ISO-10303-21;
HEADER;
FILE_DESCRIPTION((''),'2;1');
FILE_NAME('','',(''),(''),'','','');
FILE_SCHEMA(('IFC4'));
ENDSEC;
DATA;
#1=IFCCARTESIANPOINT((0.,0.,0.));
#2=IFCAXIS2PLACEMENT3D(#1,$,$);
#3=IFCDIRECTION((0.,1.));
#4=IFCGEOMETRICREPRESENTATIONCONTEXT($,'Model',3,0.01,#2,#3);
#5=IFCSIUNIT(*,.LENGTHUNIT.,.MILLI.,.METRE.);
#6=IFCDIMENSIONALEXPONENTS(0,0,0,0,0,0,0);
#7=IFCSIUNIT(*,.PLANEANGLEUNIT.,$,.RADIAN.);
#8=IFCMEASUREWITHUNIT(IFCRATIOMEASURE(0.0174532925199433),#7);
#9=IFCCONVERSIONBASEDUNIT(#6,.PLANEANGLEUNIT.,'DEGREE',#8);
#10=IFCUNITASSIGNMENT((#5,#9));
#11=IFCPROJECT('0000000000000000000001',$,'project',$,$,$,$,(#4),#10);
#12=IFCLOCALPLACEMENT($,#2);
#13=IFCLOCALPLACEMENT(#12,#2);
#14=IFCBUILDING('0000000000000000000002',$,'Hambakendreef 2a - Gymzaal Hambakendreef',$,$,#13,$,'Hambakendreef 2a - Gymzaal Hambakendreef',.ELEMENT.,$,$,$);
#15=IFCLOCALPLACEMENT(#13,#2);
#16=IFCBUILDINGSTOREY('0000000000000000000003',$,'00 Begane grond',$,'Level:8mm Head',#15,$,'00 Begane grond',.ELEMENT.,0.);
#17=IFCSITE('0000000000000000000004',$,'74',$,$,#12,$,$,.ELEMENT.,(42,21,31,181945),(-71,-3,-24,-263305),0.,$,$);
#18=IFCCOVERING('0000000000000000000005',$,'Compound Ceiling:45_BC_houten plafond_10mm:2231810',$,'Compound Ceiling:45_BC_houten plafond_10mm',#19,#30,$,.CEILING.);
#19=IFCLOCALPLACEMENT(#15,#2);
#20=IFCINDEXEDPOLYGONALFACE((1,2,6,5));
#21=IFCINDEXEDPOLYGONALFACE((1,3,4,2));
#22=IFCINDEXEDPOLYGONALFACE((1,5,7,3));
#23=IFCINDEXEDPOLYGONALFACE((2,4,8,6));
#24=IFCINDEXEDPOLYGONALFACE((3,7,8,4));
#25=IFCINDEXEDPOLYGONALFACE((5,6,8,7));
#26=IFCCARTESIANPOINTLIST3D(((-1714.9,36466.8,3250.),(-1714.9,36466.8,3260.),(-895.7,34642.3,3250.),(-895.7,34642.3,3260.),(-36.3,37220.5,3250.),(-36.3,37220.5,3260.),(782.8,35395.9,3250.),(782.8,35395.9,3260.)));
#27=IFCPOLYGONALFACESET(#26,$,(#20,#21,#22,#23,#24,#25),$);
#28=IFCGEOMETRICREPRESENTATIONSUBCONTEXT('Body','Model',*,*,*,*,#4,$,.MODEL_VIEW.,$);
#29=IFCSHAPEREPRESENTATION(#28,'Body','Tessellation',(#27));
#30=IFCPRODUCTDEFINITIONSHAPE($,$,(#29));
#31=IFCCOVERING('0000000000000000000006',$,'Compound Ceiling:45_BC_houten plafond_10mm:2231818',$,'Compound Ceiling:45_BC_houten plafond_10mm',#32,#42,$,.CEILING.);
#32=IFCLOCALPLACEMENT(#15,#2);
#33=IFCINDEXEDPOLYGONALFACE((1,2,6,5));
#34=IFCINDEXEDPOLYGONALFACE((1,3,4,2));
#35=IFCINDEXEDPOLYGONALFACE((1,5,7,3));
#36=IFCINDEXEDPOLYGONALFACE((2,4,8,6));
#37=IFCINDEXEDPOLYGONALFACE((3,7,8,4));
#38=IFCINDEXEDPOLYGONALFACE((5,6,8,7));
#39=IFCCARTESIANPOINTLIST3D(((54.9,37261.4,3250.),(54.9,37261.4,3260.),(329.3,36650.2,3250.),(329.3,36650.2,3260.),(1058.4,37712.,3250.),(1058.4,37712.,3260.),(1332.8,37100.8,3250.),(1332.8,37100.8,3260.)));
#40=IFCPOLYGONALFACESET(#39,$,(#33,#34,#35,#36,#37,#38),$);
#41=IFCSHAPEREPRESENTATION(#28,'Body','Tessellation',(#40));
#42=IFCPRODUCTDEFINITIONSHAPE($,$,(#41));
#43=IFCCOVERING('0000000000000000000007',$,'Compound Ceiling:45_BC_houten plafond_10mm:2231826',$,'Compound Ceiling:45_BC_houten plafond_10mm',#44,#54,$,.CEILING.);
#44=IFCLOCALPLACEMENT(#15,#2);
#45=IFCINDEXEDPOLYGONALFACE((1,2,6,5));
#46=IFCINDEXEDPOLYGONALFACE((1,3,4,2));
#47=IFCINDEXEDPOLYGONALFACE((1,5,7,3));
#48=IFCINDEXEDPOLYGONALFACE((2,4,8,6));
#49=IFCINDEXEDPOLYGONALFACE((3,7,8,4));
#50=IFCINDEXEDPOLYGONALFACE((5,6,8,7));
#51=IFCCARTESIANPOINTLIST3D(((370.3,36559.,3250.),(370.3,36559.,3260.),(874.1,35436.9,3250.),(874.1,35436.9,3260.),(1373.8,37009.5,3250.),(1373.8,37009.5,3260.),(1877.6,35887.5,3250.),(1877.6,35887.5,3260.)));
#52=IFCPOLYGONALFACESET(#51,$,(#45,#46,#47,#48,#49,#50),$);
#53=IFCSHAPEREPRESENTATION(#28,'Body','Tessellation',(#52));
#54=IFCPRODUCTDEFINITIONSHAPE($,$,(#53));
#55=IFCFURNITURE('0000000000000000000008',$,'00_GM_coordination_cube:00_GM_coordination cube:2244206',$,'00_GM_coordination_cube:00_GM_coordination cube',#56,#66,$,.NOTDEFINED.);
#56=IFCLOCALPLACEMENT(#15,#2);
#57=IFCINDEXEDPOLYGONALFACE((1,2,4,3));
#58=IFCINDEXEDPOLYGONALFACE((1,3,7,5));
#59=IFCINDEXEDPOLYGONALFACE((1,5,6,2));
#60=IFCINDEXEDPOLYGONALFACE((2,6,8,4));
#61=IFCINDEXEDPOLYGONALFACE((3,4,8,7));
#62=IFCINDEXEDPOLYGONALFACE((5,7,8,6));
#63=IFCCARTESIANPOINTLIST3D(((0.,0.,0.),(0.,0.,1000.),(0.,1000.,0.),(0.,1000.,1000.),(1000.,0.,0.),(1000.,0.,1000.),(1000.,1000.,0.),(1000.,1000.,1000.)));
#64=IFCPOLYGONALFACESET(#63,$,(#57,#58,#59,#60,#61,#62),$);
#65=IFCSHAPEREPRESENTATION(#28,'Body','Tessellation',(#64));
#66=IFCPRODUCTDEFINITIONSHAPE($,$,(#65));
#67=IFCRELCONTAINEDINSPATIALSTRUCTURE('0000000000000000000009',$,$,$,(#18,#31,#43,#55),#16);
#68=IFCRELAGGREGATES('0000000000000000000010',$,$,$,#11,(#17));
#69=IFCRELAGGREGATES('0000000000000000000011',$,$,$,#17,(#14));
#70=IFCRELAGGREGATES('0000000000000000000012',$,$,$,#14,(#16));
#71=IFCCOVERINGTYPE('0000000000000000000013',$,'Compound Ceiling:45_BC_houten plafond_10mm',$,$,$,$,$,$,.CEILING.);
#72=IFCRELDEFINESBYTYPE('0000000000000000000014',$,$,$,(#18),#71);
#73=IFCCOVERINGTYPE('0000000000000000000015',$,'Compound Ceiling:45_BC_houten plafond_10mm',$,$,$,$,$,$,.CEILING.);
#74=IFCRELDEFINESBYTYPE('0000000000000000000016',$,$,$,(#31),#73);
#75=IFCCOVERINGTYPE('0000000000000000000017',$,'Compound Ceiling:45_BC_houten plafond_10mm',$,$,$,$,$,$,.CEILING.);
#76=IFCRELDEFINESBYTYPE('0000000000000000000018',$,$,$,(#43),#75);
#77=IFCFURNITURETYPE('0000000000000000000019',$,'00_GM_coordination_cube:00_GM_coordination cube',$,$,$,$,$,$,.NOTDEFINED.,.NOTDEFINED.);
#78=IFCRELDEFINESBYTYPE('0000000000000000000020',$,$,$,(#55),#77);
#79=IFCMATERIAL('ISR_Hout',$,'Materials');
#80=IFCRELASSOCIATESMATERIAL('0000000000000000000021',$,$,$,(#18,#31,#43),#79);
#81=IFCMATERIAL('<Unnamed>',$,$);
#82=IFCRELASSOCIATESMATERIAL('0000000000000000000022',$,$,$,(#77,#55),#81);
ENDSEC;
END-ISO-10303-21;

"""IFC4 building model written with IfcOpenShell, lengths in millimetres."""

from ifc_helpers import new_model, entity, si_unit, converted_unit, direction, frame, origin, place, context, subcontext, project, spatial, indexed_curve, outline, extrude, source, transform, mapped, material, type_object, type_shapes, element, save


model = new_model("IFC4")

# Units and contexts
model_context = context("Model", 3, precision=0.01, world=origin(), true_north=direction((0.0, 1.0)))
body_context = subcontext(model_context, "Body", "Model", "MODEL_VIEW")
ifc_project = project(units=[si_unit("LENGTHUNIT", "METRE", prefix="MILLI"), converted_unit("PLANEANGLEUNIT", "DEGREE", entity("IfcRatioMeasure", 0.0174532925199433), si_unit("PLANEANGLEUNIT", "RADIAN"), dimensions=[0, 0, 0, 0, 0, 0, 0])], contexts=[model_context])

# Site, building, storey
site_placement = place(None, origin())
site = spatial("IfcSite", under=ifc_project, at=site_placement, Name="74", CompositionType="ELEMENT", RefLatitude=(42, 21, 31, 181945), RefLongitude=(-71, -3, -24, -263305), RefElevation=0.0)
building_placement = place(site_placement, origin())
building = spatial("IfcBuilding", under=site, at=building_placement, Name="Hambakendreef 2a - Gymzaal Hambakendreef", LongName="Hambakendreef 2a - Gymzaal Hambakendreef", CompositionType="ELEMENT")
storey_placement = place(building_placement, origin())
storey = spatial("IfcBuildingStorey", under=building, at=storey_placement, Name="00 Begane grond", ObjectType="Level:8mm Head", LongName="00 Begane grond", CompositionType="ELEMENT", Elevation=0.0)

# Shared definitions
ifc_material_1 = material(Name="<Unnamed>")

# Coverings
ifc_material_2 = material(Name="ISR_Hout", Category="Materials")
covering_type_1 = type_object("IfcCoveringType", Name="Compound Ceiling:45_BC_houten plafond_10mm", PredefinedType="CEILING")
covering_1_placement = place(storey_placement, origin())
element("IfcCovering", 1, at=covering_1_placement, inside=storey, type_object=covering_type_1, material=ifc_material_2, Name="Compound Ceiling:45_BC_houten plafond_10mm:2231810", ObjectType="Compound Ceiling:45_BC_houten plafond_10mm", PredefinedType="CEILING", context=body_context, shape_type="SweptSolid", body=[
    extrude(outline(indexed_curve([(-920.0, -1000.0), (920.0, -1000.0), (920.0, 1000.0), (-920.0, 1000.0), (-920.0, -1000.0)], self_intersect=False)), frame((-466.0, 35931.4, 3250.0), z_axis=(0.0, 0.0, 1.0), x_axis=(0.91227, 0.40959, 0.0)), (0.0, 0.0, 1.0), 10.0),
])
covering_type_2 = type_object("IfcCoveringType", Name="Compound Ceiling:45_BC_houten plafond_10mm", PredefinedType="CEILING")
covering_2_placement = place(storey_placement, origin())
element("IfcCovering", 2, at=covering_2_placement, inside=storey, type_object=covering_type_2, material=ifc_material_2, Name="Compound Ceiling:45_BC_houten plafond_10mm:2231818", ObjectType="Compound Ceiling:45_BC_houten plafond_10mm", PredefinedType="CEILING", context=body_context, shape_type="SweptSolid", body=[
    extrude(outline(indexed_curve([(-550.0, -335.0), (550.0, -335.0), (550.0, 335.0), (-550.0, 335.0), (-550.0, -335.0)], self_intersect=False)), frame((693.8, 37181.1, 3250.0), z_axis=(0.0, 0.0, 1.0), x_axis=(0.91227, 0.40959, 0.0)), (0.0, 0.0, 1.0), 10.0),
])
covering_type_3 = type_object("IfcCoveringType", Name="Compound Ceiling:45_BC_houten plafond_10mm", PredefinedType="CEILING")
covering_3_placement = place(storey_placement, origin())
element("IfcCovering", 3, at=covering_3_placement, inside=storey, type_object=covering_type_3, material=ifc_material_2, Name="Compound Ceiling:45_BC_houten plafond_10mm:2231826", ObjectType="Compound Ceiling:45_BC_houten plafond_10mm", PredefinedType="CEILING", context=body_context, shape_type="SweptSolid", body=[
    extrude(outline(indexed_curve([(-550.0, -615.0), (550.0, -615.0), (550.0, 615.0), (-550.0, 615.0), (-550.0, -615.0)], self_intersect=False)), frame((1123.9, 36223.2, 3250.0), z_axis=(0.0, 0.0, 1.0), x_axis=(-0.91227, -0.40959, 0.0)), (0.0, 0.0, 1.0), 10.0),
])

# Furniture
furniture_type = type_object("IfcFurnitureType", Name="00_GM_coordination_cube:00_GM_coordination cube", AssemblyPlace="NOTDEFINED", PredefinedType="NOTDEFINED", material=ifc_material_1)
shared_shape_1 = source(origin(), body_context, "Body", "SweptSolid", [
    extrude(outline(indexed_curve([(-500.0, -500.0), (500.0, -500.0), (500.0, 500.0), (-500.0, 500.0), (-500.0, -500.0)], self_intersect=False)), frame((500.0, 500.0, 0.0), z_axis=(0.0, 0.0, 1.0), x_axis=(0.0, 1.0, 0.0)), (0.0, 0.0, 1.0), 1000.0),
])
type_shapes(furniture_type, [shared_shape_1])
furniture_placement = place(storey_placement, origin())
element("IfcFurniture", 4, at=furniture_placement, inside=storey, type_object=furniture_type, material=ifc_material_1, Name="00_GM_coordination_cube:00_GM_coordination cube:2244206", ObjectType="00_GM_coordination_cube:00_GM_coordination cube", PredefinedType="NOTDEFINED", context=body_context, shape_type="MappedRepresentation", body=[
    mapped(shared_shape_1, transform((0.0, 0.0, 0.0), scale=1.0)),
])

save(model, "model.ifc")
